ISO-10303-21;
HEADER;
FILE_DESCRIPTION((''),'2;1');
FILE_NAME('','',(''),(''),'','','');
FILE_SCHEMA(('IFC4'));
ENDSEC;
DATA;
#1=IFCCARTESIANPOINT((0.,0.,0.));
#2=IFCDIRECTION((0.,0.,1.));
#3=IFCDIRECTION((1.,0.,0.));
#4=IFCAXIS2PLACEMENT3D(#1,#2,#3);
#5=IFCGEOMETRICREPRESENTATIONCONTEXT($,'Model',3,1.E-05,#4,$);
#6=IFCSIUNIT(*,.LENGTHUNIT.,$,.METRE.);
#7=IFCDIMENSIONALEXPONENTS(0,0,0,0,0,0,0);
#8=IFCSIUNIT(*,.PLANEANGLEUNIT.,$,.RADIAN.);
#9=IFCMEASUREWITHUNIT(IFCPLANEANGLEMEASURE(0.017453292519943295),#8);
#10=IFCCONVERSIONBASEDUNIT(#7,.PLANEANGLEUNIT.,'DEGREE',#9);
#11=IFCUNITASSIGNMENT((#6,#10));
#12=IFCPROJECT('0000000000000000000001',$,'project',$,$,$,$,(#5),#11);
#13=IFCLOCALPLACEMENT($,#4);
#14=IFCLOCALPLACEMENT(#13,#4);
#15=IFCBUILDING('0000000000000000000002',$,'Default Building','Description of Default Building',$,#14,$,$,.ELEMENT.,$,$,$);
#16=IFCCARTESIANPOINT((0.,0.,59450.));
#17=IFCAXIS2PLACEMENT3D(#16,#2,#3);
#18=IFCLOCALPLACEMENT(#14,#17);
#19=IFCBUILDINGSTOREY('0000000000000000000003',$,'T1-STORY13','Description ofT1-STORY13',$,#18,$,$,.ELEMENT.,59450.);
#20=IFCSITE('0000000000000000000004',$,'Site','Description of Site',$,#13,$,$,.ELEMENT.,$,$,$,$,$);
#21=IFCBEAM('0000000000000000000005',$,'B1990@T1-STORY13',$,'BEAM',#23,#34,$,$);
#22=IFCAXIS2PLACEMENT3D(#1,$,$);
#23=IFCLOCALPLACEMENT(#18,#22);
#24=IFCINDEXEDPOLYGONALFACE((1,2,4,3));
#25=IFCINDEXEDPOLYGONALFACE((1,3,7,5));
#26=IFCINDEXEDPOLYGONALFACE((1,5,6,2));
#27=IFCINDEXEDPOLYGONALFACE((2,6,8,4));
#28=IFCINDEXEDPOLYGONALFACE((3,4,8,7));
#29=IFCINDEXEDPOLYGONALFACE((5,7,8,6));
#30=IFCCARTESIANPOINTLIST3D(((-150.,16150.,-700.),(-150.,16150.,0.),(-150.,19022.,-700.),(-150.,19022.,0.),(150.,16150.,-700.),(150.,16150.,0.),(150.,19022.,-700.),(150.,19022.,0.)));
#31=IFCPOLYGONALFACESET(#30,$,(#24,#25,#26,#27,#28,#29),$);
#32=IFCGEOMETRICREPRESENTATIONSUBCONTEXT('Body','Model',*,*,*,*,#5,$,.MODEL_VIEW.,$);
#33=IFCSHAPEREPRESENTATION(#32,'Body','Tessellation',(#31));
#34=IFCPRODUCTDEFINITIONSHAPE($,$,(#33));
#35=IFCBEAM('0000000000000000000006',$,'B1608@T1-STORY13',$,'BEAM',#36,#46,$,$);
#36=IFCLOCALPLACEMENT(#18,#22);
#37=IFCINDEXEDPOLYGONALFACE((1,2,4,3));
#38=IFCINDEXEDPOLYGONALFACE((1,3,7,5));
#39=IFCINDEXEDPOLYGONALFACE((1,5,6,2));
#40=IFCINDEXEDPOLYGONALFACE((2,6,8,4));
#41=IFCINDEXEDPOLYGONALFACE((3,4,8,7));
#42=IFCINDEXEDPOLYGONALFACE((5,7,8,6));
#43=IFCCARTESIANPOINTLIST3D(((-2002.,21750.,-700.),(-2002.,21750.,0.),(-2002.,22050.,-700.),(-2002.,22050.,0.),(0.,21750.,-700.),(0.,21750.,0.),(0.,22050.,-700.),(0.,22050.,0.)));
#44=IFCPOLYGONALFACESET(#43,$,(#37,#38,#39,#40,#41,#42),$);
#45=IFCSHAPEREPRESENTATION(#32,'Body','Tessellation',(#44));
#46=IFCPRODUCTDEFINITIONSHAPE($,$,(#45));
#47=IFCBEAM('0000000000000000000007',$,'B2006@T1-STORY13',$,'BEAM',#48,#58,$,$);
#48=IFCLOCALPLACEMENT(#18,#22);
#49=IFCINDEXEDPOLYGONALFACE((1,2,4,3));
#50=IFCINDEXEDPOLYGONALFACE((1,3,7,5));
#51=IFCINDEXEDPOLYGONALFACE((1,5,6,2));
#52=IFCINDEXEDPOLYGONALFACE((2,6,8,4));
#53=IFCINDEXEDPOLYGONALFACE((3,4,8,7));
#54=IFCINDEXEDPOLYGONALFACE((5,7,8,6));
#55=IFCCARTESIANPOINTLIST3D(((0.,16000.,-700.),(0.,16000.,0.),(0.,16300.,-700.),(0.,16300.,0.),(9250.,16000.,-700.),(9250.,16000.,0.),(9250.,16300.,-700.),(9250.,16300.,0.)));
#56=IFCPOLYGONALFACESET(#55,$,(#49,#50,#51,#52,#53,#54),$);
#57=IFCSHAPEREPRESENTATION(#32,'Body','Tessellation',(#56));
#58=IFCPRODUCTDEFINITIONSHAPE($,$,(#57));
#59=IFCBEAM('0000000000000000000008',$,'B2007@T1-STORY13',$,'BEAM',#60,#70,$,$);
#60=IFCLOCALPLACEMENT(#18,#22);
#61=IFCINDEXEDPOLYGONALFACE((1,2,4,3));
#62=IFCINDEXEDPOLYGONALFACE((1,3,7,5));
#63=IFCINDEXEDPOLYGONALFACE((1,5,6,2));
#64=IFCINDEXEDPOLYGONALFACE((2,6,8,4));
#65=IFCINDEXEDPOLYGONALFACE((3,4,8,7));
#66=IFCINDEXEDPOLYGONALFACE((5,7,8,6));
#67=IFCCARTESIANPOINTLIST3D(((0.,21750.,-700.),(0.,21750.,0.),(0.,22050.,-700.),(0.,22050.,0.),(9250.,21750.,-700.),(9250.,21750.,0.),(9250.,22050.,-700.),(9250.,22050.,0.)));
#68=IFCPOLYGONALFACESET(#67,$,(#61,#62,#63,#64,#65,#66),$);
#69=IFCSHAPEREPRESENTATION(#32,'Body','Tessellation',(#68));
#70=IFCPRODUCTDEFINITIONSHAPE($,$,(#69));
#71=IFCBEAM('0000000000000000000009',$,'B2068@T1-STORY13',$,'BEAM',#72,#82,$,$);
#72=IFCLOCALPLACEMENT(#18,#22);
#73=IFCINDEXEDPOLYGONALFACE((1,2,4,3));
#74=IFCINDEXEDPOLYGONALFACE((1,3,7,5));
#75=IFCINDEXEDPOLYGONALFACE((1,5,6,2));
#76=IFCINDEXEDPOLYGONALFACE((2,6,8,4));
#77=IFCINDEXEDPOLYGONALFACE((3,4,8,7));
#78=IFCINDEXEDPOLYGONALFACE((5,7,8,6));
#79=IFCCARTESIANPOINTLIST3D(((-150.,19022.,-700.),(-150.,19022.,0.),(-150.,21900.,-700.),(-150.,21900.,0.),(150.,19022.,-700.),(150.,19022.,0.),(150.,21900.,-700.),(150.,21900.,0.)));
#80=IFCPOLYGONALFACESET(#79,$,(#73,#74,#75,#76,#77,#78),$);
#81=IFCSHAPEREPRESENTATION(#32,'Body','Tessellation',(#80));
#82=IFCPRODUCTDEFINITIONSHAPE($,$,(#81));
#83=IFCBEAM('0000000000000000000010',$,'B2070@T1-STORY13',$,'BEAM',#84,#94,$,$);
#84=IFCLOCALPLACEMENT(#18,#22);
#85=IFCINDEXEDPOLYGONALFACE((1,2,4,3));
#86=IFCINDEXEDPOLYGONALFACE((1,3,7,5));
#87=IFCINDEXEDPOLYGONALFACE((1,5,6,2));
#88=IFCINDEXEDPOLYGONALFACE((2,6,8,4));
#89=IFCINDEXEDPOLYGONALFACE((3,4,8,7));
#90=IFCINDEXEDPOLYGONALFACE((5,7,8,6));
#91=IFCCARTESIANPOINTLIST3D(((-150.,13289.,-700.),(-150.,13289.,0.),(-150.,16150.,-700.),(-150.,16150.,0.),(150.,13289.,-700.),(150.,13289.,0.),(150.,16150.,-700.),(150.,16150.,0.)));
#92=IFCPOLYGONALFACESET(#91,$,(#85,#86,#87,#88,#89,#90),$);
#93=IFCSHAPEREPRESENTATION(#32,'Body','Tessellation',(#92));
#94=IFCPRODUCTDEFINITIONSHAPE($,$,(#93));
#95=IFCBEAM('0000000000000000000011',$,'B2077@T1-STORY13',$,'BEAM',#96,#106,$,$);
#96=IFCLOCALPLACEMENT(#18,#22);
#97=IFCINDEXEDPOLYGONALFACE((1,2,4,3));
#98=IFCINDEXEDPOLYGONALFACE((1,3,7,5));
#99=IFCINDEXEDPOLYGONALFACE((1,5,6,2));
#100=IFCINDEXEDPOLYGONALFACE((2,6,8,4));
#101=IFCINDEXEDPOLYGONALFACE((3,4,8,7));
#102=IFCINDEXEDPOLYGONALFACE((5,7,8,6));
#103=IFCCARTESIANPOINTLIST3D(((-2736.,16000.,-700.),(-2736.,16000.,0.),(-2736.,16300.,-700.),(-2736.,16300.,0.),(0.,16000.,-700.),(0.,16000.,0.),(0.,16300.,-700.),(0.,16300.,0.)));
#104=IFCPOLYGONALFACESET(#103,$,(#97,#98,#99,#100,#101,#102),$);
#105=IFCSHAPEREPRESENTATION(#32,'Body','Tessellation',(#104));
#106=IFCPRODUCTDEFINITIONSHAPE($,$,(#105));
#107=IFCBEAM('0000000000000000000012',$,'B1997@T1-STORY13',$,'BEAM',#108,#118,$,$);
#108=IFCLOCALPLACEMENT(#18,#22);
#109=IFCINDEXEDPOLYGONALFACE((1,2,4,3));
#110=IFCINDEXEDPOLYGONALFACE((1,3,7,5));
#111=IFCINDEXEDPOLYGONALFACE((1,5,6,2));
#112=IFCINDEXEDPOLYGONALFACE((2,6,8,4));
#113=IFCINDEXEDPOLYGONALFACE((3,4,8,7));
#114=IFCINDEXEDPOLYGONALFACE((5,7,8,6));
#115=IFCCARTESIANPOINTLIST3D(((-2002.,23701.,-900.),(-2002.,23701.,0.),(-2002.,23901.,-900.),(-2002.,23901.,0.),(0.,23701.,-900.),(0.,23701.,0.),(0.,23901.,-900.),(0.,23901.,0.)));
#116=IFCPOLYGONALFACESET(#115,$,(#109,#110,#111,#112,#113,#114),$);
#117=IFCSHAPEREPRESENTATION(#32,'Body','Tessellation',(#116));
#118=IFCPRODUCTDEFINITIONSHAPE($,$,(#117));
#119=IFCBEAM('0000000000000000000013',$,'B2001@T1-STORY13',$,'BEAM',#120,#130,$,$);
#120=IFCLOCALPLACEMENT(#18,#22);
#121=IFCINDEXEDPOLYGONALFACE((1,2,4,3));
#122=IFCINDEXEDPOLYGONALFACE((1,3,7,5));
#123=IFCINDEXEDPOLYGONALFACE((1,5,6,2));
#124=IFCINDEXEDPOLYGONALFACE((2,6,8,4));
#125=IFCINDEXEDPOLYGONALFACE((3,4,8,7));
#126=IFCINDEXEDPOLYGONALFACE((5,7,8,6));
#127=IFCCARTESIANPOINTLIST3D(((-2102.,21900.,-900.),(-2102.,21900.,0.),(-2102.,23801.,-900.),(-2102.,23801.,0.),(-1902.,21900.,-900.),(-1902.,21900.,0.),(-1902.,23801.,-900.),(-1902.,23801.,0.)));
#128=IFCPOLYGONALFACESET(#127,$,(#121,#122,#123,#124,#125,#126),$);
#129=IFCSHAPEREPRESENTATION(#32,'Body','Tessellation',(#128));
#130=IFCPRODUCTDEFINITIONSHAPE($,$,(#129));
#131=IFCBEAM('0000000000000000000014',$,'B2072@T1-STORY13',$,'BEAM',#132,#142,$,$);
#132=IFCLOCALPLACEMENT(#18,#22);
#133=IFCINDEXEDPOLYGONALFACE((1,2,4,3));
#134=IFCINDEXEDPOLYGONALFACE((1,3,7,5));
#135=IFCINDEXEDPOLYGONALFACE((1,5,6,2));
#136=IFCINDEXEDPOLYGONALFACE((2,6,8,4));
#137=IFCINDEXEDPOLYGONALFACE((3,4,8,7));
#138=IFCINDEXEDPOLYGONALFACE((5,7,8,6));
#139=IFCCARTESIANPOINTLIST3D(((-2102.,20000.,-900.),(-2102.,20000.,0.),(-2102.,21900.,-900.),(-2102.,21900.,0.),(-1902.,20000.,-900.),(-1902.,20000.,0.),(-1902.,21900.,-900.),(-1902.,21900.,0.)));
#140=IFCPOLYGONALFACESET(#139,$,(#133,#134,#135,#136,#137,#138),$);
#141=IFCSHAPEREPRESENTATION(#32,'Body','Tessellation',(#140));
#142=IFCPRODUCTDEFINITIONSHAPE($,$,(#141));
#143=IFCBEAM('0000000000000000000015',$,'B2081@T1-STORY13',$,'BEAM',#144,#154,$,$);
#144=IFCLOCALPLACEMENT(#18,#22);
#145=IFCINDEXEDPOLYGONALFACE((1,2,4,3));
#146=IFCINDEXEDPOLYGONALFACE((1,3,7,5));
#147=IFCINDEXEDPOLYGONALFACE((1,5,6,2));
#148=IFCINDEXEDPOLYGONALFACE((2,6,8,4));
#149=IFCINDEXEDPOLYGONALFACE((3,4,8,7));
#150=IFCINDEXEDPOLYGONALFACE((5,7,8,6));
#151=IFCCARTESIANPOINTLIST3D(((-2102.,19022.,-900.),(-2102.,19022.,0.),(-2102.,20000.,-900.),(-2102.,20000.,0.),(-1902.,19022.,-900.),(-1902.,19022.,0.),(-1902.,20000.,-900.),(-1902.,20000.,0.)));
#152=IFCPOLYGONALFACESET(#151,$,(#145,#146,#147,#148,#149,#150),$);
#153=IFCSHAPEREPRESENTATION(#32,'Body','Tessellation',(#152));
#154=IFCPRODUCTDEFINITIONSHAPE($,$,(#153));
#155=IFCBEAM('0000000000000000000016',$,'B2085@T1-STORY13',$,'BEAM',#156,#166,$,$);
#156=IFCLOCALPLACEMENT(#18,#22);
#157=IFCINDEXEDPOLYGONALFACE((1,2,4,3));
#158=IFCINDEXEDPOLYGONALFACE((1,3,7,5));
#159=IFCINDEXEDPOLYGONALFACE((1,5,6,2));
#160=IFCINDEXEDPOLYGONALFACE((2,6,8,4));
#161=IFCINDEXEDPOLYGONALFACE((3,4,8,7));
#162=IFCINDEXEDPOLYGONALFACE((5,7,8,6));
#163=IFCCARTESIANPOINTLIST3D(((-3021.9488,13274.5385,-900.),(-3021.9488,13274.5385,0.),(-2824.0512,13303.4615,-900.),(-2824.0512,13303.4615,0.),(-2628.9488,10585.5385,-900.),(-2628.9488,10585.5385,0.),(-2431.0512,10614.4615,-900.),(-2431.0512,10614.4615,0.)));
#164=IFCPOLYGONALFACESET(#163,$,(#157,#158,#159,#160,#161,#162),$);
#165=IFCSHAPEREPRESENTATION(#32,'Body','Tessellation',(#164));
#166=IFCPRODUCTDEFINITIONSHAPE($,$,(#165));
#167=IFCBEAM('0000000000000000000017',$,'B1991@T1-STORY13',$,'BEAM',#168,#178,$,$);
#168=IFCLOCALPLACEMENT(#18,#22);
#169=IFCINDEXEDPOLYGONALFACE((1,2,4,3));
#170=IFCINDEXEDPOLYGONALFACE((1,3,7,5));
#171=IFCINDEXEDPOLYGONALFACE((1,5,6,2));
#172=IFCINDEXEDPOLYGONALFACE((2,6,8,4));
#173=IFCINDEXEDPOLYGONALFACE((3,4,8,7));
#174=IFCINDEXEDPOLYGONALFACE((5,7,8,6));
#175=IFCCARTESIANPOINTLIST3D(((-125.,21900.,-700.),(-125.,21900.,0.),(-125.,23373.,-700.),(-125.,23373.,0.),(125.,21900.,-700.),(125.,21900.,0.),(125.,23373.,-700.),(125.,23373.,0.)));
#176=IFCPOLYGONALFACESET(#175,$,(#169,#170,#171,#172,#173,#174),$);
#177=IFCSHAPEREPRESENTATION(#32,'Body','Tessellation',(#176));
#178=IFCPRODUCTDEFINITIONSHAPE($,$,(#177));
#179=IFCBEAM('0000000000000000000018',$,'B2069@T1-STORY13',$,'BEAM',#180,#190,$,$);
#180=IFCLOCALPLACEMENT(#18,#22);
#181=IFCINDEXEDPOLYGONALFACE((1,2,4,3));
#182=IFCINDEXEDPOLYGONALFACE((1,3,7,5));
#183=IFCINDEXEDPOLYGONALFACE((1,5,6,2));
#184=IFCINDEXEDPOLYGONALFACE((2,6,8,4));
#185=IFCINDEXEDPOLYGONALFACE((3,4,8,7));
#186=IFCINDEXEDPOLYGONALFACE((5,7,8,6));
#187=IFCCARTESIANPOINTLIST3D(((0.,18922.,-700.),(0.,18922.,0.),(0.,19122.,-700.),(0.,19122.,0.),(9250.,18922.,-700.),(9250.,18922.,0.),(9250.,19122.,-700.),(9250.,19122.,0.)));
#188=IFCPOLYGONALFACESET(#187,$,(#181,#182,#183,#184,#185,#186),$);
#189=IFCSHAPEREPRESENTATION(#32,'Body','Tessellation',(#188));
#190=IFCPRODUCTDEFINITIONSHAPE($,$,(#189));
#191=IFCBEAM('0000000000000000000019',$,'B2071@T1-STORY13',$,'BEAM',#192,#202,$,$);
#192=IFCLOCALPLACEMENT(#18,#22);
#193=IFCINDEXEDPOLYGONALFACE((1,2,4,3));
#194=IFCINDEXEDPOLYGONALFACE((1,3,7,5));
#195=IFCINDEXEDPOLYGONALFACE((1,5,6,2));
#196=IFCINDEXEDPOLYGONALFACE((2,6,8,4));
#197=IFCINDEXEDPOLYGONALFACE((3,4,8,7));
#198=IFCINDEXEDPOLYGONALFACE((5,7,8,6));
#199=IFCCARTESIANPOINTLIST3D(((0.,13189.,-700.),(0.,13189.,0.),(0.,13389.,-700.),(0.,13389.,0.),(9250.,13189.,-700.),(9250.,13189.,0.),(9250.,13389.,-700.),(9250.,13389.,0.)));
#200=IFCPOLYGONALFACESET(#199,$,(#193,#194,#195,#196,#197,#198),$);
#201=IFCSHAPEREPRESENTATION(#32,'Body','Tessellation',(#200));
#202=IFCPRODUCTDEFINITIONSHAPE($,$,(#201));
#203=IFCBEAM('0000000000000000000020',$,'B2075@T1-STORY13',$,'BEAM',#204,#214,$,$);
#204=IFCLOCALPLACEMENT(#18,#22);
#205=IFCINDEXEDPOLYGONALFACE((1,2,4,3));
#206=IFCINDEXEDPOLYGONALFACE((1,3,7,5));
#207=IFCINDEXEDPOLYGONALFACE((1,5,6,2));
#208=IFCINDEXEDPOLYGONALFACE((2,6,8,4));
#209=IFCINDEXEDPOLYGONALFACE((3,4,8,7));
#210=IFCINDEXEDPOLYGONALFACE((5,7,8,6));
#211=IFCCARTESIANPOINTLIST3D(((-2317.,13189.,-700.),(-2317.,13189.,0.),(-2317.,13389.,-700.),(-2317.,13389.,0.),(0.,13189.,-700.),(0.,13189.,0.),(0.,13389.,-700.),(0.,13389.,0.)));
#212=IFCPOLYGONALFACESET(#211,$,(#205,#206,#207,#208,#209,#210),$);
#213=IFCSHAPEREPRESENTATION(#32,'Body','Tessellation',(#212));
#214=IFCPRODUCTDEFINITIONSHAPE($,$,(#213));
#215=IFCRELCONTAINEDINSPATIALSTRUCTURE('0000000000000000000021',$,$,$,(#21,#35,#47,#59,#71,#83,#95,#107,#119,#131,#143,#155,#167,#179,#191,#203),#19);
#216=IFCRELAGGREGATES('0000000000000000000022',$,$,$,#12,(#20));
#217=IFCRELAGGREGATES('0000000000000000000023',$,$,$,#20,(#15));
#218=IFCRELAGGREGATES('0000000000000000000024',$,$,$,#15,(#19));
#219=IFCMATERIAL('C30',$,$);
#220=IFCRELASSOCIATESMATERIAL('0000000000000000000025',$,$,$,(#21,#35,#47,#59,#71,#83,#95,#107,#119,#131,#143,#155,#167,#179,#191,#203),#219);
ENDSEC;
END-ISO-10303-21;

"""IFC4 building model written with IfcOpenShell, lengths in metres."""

from ifc_helpers import new_model, entity, si_unit, converted_unit, frame, origin_with_axes, place, context, subcontext, project, spatial, rectangle, extrude, material, element, save


model = new_model("IFC4")

# Units and contexts
model_context = context("Model", 3, precision=1e-05, world=origin_with_axes())
body_context = subcontext(model_context, "Body", "Model", "MODEL_VIEW")
ifc_project = project(units=[si_unit("LENGTHUNIT", "METRE"), converted_unit("PLANEANGLEUNIT", "DEGREE", entity("IfcPlaneAngleMeasure", 0.017453292519943295), si_unit("PLANEANGLEUNIT", "RADIAN"), dimensions=[0, 0, 0, 0, 0, 0, 0])], contexts=[model_context])

# Site, building, storey
site_placement = place(None, origin_with_axes())
site = spatial("IfcSite", under=ifc_project, at=site_placement, Name="Site", Description="Description of Site", CompositionType="ELEMENT")
building_placement = place(site_placement, origin_with_axes())
building = spatial("IfcBuilding", under=site, at=building_placement, Name="Default Building", Description="Description of Default Building", CompositionType="ELEMENT")
storey_placement = place(building_placement, frame((0.0, 0.0, 59450.0), z_axis=(0.0, 0.0, 1.0), x_axis=(1.0, 0.0, 0.0)))
storey = spatial("IfcBuildingStorey", under=building, at=storey_placement, Name="T1-STORY13", Description="Description ofT1-STORY13", CompositionType="ELEMENT", Elevation=59450.0)

# Beams
ifc_material_1 = material(Name="C30")
beam_1_placement = place(storey_placement, frame((0.0, 16150.0, -350.0), z_axis=(0.0, 1.0, 0.0), x_axis=(-1.0, 0.0, 0.0)))
element("IfcBeam", 1, at=beam_1_placement, inside=storey, material=ifc_material_1, Name="B1990@T1-STORY13", ObjectType="BEAM", context=body_context, shape_type="SweptSolid", body=[
    extrude(rectangle(XDim=300.0, YDim=700.0), origin_with_axes(), (0.0, 0.0, 1.0), 2872.0),
])
beam_2_placement = place(storey_placement, frame((-2002.0, 21900.0, -350.0), z_axis=(1.0, 0.0, 0.0), x_axis=(0.0, 1.0, 0.0)))
element("IfcBeam", 2, at=beam_2_placement, inside=storey, material=ifc_material_1, Name="B1608@T1-STORY13", ObjectType="BEAM", context=body_context, shape_type="SweptSolid", body=[
    extrude(rectangle(XDim=300.0, YDim=700.0), origin_with_axes(), (0.0, 0.0, 1.0), 2002.0),
])
for number, where, z_axis, x_axis, name in (
    (3, (0.0, 16150.0, -350.0), (1.0, 0.0, 0.0), (0.0, 1.0, 0.0), "B2006@T1-STORY13"),
    (4, (0.0, 21900.0, -350.0), (1.0, 0.0, 0.0), (0.0, 1.0, 0.0), "B2007@T1-STORY13"),
):
    element("IfcBeam", number, at=place(storey_placement, frame(where, z_axis=z_axis, x_axis=x_axis)), inside=storey, material=ifc_material_1, Name=name, ObjectType="BEAM", context=body_context, shape_type="SweptSolid", body=[
        extrude(rectangle(XDim=300.0, YDim=700.0), origin_with_axes(), (0.0, 0.0, 1.0), 9250.0),
    ])
beam_3_placement = place(storey_placement, frame((0.0, 19022.0, -350.0), z_axis=(0.0, 1.0, 0.0), x_axis=(-1.0, 0.0, 0.0)))
element("IfcBeam", 5, at=beam_3_placement, inside=storey, material=ifc_material_1, Name="B2068@T1-STORY13", ObjectType="BEAM", context=body_context, shape_type="SweptSolid", body=[
    extrude(rectangle(XDim=300.0, YDim=700.0), origin_with_axes(), (0.0, 0.0, 1.0), 2878.0),
])
beam_4_placement = place(storey_placement, frame((0.0, 13289.0, -350.0), z_axis=(0.0, 1.0, 0.0), x_axis=(-1.0, 0.0, 0.0)))
element("IfcBeam", 6, at=beam_4_placement, inside=storey, material=ifc_material_1, Name="B2070@T1-STORY13", ObjectType="BEAM", context=body_context, shape_type="SweptSolid", body=[
    extrude(rectangle(XDim=300.0, YDim=700.0), origin_with_axes(), (0.0, 0.0, 1.0), 2861.0),
])
beam_5_placement = place(storey_placement, frame((-2736.0, 16150.0, -350.0), z_axis=(1.0, 0.0, 0.0), x_axis=(0.0, 1.0, 0.0)))
element("IfcBeam", 7, at=beam_5_placement, inside=storey, material=ifc_material_1, Name="B2077@T1-STORY13", ObjectType="BEAM", context=body_context, shape_type="SweptSolid", body=[
    extrude(rectangle(XDim=300.0, YDim=700.0), origin_with_axes(), (0.0, 0.0, 1.0), 2736.0),
])
beam_6_placement = place(storey_placement, frame((-2002.0, 23801.0, -450.0), z_axis=(1.0, 0.0, 0.0), x_axis=(0.0, 1.0, 0.0)))
element("IfcBeam", 8, at=beam_6_placement, inside=storey, material=ifc_material_1, Name="B1997@T1-STORY13", ObjectType="BEAM", context=body_context, shape_type="SweptSolid", body=[
    extrude(rectangle(XDim=200.0, YDim=900.0), origin_with_axes(), (0.0, 0.0, 1.0), 2002.0),
])
beam_7_placement = place(storey_placement, frame((-2002.0, 21900.0, -450.0), z_axis=(0.0, 1.0, 0.0), x_axis=(-1.0, 0.0, 0.0)))
element("IfcBeam", 9, at=beam_7_placement, inside=storey, material=ifc_material_1, Name="B2001@T1-STORY13", ObjectType="BEAM", context=body_context, shape_type="SweptSolid", body=[
    extrude(rectangle(XDim=200.0, YDim=900.0), origin_with_axes(), (0.0, 0.0, 1.0), 1901.0),
])
beam_8_placement = place(storey_placement, frame((-2002.0, 20000.0, -450.0), z_axis=(0.0, 1.0, 0.0), x_axis=(-1.0, 0.0, 0.0)))
element("IfcBeam", 10, at=beam_8_placement, inside=storey, material=ifc_material_1, Name="B2072@T1-STORY13", ObjectType="BEAM", context=body_context, shape_type="SweptSolid", body=[
    extrude(rectangle(XDim=200.0, YDim=900.0), origin_with_axes(), (0.0, 0.0, 1.0), 1900.0),
])
beam_9_placement = place(storey_placement, frame((-2002.0, 19022.0, -450.0), z_axis=(0.0, 1.0, 0.0), x_axis=(-1.0, 0.0, 0.0)))
element("IfcBeam", 11, at=beam_9_placement, inside=storey, material=ifc_material_1, Name="B2081@T1-STORY13", ObjectType="BEAM", context=body_context, shape_type="SweptSolid", body=[
    extrude(rectangle(XDim=200.0, YDim=900.0), origin_with_axes(), (0.0, 0.0, 1.0), 978.0),
])
beam_10_placement = place(storey_placement, frame((-2923.0, 13289.0, -450.0), z_axis=(0.144615, -0.989488, 0.0), x_axis=(0.989488, 0.144615, 0.0)))
element("IfcBeam", 12, at=beam_10_placement, inside=storey, material=ifc_material_1, Name="B2085@T1-STORY13", ObjectType="BEAM", context=body_context, shape_type="SweptSolid", body=[
    extrude(rectangle(XDim=200.0, YDim=900.0), origin_with_axes(), (0.0, 0.0, 1.0), 2717.5669),
])
beam_11_placement = place(storey_placement, frame((0.0, 21900.0, -350.0), z_axis=(0.0, 1.0, 0.0), x_axis=(-1.0, 0.0, 0.0)))
element("IfcBeam", 13, at=beam_11_placement, inside=storey, material=ifc_material_1, Name="B1991@T1-STORY13", ObjectType="BEAM", context=body_context, shape_type="SweptSolid", body=[
    extrude(rectangle(XDim=250.0, YDim=700.0), origin_with_axes(), (0.0, 0.0, 1.0), 1473.0),
])
for number, where, z_axis, x_axis, name in (
    (14, (0.0, 19022.0, -350.0), (1.0, 0.0, 0.0), (0.0, 1.0, 0.0), "B2069@T1-STORY13"),
    (15, (0.0, 13289.0, -350.0), (1.0, 0.0, 0.0), (0.0, 1.0, 0.0), "B2071@T1-STORY13"),
):
    element("IfcBeam", number, at=place(storey_placement, frame(where, z_axis=z_axis, x_axis=x_axis)), inside=storey, material=ifc_material_1, Name=name, ObjectType="BEAM", context=body_context, shape_type="SweptSolid", body=[
        extrude(rectangle(XDim=200.0, YDim=700.0), origin_with_axes(), (0.0, 0.0, 1.0), 9250.0),
    ])
beam_12_placement = place(storey_placement, frame((-2317.0, 13289.0, -350.0), z_axis=(1.0, 0.0, 0.0), x_axis=(0.0, 1.0, 0.0)))
element("IfcBeam", 16, at=beam_12_placement, inside=storey, material=ifc_material_1, Name="B2075@T1-STORY13", ObjectType="BEAM", context=body_context, shape_type="SweptSolid", body=[
    extrude(rectangle(XDim=200.0, YDim=700.0), origin_with_axes(), (0.0, 0.0, 1.0), 2317.0),
])

save(model, "model.ifc")
